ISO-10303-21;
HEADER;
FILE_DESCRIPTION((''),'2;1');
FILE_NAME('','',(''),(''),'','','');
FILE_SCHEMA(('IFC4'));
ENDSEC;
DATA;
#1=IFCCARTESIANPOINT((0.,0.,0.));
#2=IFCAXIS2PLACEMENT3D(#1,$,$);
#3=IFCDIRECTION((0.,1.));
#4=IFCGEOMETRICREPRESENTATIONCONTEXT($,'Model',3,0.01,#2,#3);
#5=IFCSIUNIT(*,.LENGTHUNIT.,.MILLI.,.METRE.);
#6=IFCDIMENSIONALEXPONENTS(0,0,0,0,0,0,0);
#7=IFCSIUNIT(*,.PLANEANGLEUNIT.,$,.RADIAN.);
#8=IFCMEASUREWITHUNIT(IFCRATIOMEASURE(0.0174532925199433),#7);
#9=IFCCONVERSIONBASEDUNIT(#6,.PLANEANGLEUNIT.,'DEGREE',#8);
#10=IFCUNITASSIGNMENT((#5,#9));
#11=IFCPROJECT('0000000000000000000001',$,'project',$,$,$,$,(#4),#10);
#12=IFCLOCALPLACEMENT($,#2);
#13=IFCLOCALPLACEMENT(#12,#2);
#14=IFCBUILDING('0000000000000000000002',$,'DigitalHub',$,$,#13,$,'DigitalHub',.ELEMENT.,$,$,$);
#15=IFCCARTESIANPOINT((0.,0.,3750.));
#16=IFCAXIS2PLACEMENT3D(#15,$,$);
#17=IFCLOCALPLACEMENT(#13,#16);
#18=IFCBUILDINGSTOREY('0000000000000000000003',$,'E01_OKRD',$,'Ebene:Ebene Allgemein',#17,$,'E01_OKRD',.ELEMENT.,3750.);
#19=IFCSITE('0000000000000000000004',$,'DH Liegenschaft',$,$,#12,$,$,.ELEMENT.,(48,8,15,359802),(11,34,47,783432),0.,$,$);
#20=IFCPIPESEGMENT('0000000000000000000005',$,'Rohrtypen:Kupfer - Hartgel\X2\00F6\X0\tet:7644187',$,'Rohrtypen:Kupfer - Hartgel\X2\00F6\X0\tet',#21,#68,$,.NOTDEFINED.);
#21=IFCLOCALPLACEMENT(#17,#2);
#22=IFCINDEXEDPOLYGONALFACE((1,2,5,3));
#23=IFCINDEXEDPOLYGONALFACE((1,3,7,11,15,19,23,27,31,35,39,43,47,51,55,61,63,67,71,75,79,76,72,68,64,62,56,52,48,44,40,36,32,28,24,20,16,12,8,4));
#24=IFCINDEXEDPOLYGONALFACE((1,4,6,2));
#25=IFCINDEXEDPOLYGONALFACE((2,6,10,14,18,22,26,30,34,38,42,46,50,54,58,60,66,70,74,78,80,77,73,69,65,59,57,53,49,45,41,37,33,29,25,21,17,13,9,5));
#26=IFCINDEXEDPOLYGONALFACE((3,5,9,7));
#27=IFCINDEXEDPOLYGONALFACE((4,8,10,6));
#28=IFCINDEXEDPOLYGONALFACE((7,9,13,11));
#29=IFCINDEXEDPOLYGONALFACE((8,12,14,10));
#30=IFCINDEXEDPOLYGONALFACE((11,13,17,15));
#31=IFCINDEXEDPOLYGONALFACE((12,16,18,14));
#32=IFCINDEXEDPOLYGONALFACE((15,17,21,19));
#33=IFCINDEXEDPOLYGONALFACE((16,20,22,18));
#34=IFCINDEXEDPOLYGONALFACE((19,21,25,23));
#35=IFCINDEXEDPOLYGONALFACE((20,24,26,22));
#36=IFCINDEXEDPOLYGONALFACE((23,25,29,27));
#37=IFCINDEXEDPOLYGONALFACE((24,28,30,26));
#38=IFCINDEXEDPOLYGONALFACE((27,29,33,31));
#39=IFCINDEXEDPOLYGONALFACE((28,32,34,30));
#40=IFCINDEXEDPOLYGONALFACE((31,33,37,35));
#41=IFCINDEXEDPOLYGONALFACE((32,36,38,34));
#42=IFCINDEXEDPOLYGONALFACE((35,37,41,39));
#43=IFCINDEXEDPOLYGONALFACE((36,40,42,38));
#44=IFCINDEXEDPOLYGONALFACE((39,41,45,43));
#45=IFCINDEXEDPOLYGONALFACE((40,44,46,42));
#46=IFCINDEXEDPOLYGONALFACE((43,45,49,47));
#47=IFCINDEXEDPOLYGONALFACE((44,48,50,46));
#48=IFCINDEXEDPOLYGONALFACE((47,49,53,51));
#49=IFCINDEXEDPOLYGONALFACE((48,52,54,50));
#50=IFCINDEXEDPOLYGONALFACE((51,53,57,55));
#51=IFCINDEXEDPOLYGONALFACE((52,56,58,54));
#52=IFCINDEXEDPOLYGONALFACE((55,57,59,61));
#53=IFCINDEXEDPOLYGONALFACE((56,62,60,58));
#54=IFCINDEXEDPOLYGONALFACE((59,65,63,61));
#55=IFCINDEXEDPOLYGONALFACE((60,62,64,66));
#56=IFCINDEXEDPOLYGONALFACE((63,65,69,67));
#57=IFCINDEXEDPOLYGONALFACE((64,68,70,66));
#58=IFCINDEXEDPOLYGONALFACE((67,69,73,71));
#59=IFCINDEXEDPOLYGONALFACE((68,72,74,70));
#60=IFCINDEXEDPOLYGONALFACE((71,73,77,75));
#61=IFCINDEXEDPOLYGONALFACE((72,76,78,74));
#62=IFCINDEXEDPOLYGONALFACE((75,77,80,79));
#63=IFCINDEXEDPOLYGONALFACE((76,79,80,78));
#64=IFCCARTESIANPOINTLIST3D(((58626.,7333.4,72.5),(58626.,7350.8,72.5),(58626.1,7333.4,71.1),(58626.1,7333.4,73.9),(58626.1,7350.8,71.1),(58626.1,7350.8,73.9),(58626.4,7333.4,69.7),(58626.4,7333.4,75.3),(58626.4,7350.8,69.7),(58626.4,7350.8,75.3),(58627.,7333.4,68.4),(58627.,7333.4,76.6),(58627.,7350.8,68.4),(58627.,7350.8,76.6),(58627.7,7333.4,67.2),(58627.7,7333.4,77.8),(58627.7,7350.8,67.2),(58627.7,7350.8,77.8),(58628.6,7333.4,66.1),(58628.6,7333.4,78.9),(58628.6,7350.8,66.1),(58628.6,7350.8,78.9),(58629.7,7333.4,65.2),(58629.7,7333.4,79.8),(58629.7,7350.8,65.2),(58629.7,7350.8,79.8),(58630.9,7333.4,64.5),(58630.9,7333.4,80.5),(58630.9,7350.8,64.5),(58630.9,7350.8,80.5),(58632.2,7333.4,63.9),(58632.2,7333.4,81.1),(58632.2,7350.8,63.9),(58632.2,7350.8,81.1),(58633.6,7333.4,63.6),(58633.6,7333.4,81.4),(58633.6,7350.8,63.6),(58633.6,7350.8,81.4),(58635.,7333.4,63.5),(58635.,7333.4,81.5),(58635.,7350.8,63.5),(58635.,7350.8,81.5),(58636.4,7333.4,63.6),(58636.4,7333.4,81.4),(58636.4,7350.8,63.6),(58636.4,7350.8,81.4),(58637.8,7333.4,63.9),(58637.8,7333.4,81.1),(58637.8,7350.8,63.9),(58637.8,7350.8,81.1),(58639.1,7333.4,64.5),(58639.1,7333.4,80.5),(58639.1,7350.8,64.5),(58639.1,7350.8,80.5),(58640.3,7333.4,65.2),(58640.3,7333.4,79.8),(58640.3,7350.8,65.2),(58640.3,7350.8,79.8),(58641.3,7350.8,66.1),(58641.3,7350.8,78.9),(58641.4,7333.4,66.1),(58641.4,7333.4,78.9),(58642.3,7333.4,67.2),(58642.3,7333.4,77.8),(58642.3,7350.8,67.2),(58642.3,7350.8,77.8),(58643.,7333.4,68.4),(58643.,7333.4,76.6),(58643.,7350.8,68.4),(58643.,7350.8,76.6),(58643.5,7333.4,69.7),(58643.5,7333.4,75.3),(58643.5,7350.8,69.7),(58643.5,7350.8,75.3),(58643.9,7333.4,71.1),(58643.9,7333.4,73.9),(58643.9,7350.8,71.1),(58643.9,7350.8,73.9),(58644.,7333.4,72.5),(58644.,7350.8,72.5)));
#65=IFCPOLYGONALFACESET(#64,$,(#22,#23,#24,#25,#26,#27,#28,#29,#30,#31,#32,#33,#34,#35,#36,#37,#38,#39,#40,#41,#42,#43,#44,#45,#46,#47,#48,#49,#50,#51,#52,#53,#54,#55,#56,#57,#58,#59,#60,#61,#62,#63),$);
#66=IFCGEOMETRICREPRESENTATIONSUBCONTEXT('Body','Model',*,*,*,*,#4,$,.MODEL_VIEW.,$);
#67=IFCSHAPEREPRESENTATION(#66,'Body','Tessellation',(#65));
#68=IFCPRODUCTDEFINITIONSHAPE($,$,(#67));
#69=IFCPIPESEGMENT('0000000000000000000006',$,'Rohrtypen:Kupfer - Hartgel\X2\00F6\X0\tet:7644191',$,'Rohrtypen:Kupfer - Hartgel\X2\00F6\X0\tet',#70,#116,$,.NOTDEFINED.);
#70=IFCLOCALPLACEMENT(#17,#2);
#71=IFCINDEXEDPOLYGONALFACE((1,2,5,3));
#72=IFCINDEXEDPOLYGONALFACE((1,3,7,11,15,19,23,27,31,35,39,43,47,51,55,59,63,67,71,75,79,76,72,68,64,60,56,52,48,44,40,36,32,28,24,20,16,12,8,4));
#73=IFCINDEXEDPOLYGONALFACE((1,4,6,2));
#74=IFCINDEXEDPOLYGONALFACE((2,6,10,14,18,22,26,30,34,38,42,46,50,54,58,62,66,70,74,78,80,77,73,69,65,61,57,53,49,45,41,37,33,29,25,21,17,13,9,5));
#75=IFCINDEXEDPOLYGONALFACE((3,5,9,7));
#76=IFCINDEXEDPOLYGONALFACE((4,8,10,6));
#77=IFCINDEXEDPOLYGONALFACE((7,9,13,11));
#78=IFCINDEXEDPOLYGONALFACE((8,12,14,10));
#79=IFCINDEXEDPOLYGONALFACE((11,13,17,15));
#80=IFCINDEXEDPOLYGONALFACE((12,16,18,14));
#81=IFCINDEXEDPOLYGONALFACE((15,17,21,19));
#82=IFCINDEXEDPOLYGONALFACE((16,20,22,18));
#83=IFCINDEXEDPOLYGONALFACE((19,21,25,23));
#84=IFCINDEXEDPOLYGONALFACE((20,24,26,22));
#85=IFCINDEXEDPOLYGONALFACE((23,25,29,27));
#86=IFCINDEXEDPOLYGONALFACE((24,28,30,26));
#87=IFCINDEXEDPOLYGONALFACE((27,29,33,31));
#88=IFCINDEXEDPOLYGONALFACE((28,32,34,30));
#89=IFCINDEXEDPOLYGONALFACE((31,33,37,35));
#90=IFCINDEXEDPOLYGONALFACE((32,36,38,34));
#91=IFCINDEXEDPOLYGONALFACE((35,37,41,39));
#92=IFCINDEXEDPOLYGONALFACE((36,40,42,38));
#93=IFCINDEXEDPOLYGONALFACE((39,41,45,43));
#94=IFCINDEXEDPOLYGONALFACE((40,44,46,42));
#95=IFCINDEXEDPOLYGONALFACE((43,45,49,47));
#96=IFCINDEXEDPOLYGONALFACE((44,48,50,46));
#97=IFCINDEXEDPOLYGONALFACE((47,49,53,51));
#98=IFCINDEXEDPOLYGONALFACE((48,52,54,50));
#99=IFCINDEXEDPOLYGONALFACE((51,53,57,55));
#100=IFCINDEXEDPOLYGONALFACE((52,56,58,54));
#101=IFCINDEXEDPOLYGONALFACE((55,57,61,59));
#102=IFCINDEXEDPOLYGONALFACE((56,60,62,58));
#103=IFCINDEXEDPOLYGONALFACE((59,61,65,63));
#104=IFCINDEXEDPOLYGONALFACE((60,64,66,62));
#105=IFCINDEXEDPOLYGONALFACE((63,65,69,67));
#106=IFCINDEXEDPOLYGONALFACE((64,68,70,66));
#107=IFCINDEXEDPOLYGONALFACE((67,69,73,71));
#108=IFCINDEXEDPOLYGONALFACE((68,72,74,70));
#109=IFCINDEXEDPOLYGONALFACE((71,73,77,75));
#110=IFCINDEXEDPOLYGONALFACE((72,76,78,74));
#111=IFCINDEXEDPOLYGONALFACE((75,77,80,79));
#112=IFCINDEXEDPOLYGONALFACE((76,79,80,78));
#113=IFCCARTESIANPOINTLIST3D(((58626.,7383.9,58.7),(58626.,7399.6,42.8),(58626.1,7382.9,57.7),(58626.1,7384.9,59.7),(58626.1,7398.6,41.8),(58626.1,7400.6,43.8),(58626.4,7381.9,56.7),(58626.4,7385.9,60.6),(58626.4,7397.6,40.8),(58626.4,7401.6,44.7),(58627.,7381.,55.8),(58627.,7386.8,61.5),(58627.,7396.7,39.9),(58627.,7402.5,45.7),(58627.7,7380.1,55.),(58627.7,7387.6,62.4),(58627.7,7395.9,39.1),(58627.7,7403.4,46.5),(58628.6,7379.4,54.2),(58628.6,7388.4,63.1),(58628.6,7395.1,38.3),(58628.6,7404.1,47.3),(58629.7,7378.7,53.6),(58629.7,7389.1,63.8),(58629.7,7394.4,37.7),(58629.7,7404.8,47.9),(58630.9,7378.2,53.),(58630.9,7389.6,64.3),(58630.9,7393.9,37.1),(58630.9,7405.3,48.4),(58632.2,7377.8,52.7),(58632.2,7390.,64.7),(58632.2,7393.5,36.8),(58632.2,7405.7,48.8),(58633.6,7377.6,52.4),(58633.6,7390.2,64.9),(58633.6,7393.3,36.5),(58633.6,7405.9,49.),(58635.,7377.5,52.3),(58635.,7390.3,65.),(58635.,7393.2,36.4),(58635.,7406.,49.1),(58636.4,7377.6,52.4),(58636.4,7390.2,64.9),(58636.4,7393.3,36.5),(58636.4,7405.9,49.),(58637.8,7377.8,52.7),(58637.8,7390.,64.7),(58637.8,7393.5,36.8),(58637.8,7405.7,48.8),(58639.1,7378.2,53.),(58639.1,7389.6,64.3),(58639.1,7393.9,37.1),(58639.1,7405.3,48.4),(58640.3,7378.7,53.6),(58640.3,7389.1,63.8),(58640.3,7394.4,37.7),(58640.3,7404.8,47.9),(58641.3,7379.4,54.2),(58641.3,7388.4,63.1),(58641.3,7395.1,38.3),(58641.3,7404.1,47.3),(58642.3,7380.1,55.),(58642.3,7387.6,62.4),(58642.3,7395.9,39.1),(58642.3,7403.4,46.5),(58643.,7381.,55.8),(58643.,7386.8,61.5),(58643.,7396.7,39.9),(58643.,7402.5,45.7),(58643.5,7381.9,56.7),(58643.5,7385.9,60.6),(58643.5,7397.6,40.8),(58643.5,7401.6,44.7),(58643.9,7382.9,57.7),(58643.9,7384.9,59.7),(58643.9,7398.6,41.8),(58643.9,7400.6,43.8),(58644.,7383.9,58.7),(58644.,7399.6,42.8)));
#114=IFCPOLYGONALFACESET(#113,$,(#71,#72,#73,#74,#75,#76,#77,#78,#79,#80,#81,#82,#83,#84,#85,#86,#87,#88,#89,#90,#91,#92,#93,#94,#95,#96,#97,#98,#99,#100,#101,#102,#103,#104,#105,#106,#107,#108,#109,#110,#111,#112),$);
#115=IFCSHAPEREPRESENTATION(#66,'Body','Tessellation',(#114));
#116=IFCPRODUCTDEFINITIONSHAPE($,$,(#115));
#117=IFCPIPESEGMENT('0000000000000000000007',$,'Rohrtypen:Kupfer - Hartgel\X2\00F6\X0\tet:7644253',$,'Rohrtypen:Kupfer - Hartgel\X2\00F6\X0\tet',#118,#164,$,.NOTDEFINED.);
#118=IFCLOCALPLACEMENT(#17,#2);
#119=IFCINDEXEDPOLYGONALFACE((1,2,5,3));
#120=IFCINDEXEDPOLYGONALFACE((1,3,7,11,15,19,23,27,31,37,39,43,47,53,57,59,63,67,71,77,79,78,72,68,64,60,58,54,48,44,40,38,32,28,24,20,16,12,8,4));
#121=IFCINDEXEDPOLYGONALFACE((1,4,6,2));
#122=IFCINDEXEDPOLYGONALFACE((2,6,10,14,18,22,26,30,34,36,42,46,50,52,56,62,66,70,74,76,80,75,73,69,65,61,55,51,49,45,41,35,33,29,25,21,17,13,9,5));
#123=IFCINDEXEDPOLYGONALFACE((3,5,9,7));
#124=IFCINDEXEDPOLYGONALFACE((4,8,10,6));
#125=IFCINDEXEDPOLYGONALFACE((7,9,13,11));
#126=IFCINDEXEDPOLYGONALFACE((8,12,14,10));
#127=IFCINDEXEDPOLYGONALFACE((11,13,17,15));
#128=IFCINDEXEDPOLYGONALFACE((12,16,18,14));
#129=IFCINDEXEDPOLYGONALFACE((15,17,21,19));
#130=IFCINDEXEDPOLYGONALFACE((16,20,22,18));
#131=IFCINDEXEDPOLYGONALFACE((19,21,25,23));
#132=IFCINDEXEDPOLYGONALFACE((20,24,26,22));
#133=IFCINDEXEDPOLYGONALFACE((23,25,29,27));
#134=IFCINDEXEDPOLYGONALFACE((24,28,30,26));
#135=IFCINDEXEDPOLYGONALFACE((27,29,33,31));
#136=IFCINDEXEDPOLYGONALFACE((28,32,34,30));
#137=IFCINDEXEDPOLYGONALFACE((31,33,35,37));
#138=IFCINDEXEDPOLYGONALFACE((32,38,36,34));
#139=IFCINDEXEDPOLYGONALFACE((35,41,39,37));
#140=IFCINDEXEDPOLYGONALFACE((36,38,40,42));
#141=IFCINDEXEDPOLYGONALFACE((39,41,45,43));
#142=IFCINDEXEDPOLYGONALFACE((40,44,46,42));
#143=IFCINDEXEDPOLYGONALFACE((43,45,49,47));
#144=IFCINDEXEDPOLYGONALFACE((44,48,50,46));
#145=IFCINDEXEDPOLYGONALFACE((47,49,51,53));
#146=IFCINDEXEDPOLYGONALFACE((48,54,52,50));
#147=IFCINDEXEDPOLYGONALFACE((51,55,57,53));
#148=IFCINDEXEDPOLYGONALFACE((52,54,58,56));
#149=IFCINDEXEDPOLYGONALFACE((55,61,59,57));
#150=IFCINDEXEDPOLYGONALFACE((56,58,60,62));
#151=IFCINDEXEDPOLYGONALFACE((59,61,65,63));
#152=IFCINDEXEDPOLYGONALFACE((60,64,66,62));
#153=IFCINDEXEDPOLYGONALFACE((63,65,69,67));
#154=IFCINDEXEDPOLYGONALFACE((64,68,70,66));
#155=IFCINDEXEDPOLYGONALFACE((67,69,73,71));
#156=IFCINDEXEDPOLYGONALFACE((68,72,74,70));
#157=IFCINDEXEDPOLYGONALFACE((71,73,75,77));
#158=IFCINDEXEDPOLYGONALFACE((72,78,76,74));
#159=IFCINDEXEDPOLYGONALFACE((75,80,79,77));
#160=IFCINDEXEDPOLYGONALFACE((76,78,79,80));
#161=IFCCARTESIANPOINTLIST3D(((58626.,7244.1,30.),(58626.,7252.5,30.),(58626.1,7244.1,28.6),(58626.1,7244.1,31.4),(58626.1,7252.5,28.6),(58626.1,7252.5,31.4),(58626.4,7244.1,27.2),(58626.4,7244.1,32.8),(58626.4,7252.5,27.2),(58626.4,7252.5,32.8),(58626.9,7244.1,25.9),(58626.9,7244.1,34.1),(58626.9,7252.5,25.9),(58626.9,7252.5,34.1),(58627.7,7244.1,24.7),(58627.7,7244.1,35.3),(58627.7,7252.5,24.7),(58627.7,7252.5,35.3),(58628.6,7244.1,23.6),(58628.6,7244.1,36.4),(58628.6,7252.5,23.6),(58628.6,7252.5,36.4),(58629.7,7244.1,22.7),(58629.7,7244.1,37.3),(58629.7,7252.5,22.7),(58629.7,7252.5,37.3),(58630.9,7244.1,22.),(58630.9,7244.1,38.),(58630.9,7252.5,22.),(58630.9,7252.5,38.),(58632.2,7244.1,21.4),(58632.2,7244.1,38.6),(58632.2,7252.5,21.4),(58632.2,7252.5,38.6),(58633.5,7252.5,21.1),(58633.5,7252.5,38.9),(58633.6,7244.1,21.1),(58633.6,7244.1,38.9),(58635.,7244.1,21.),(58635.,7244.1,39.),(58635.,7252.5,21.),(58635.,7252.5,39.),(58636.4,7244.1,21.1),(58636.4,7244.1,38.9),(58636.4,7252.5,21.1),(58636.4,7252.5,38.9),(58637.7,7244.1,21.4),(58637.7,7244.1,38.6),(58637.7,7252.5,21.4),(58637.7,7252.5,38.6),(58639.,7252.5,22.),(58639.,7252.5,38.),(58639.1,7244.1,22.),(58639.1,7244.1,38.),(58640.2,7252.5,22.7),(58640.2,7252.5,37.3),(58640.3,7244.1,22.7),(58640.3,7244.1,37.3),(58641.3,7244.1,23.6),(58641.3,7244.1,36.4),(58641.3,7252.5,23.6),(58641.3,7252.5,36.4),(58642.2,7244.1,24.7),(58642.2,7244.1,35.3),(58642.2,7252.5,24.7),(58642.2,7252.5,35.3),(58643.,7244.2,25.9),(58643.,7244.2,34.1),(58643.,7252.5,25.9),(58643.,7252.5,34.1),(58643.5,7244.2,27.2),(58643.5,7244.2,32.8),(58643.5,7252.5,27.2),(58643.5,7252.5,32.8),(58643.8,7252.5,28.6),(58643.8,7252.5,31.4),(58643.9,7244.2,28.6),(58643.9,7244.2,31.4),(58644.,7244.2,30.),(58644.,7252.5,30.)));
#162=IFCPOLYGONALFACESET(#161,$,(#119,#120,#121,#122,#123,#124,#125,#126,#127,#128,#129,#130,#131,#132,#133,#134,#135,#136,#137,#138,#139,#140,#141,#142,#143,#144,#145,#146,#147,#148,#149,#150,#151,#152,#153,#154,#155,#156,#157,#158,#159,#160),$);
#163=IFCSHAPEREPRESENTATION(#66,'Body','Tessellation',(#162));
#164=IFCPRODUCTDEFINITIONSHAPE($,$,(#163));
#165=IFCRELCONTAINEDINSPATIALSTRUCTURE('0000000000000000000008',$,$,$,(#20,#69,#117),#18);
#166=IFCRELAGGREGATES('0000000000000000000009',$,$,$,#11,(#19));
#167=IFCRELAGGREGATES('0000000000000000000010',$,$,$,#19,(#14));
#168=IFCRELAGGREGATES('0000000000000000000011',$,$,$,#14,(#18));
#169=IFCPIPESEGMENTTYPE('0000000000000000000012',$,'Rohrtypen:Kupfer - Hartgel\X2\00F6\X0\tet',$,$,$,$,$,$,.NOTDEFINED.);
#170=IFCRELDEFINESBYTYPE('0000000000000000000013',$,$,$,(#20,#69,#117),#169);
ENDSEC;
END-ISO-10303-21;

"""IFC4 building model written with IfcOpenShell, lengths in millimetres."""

from ifc_helpers import new_model, entity, si_unit, converted_unit, direction, frame, origin, place, context, subcontext, project, spatial, indexed_curve, outline, extrude, type_object, element, save


model = new_model("IFC4")

# Units and contexts
model_context = context("Model", 3, precision=0.01, world=origin(), true_north=direction((0.0, 1.0)))
body_context = subcontext(model_context, "Body", "Model", "MODEL_VIEW")
ifc_project = project(units=[si_unit("LENGTHUNIT", "METRE", prefix="MILLI"), converted_unit("PLANEANGLEUNIT", "DEGREE", entity("IfcRatioMeasure", 0.0174532925199433), si_unit("PLANEANGLEUNIT", "RADIAN"), dimensions=[0, 0, 0, 0, 0, 0, 0])], contexts=[model_context])

# Site, building, storey
site_placement = place(None, origin())
site = spatial("IfcSite", under=ifc_project, at=site_placement, Name="DH Liegenschaft", CompositionType="ELEMENT", RefLatitude=(48, 8, 15, 359802), RefLongitude=(11, 34, 47, 783432), RefElevation=0.0)
building_placement = place(site_placement, origin())
building = spatial("IfcBuilding", under=site, at=building_placement, Name="DigitalHub", LongName="DigitalHub", CompositionType="ELEMENT")
storey_placement = place(building_placement, frame((0.0, 0.0, 3750.0)))
storey = spatial("IfcBuildingStorey", under=building, at=storey_placement, Name="E01_OKRD", ObjectType="Ebene:Ebene Allgemein", LongName="E01_OKRD", CompositionType="ELEMENT", Elevation=3750.0)

# Pipe segments
pipe_segment_type = type_object("IfcPipeSegmentType", Name="Rohrtypen:Kupfer - Hartgelötet", PredefinedType="NOTDEFINED")
pipe_segment_1_placement = place(storey_placement, frame((58624.4, 7333.4, 61.9)))
element("IfcPipeSegment", 1, at=pipe_segment_1_placement, inside=storey, type_object=pipe_segment_type, Name="Rohrtypen:Kupfer - Hartgelötet:7644187", ObjectType="Rohrtypen:Kupfer - Hartgelötet", PredefinedType="NOTDEFINED", context=body_context, shape_type="SweptSolid", body=[
    extrude(outline(indexed_curve([(9.0, 0.0), (8.9, 1.4), (8.6, 2.8), (8.0, 4.1), (7.3, 5.3), (6.4, 6.4), (5.3, 7.3), (4.1, 8.0), (2.8, 8.6), (1.4, 8.9), (0.0, 9.0), (-1.4, 8.9), (-2.8, 8.6), (-4.1, 8.0), (-5.3, 7.3), (-6.4, 6.4), (-7.3, 5.3), (-8.0, 4.1), (-8.6, 2.8), (-8.9, 1.4), (-9.0, 0.0), (-8.9, -1.4), (-8.6, -2.8), (-8.0, -4.1), (-7.3, -5.3), (-6.4, -6.4), (-5.3, -7.3), (-4.1, -8.0), (-2.8, -8.6), (-1.4, -8.9), (0.0, -9.0), (1.4, -8.9), (2.8, -8.6), (4.1, -8.0), (5.3, -7.3), (6.4, -6.4), (7.3, -5.3), (8.0, -4.1), (8.6, -2.8), (8.9, -1.4), (9.0, 0.0)], self_intersect=False)), frame((10.6, 17.5, 10.6), z_axis=(0.00028, -1.0, 0.000282), x_axis=(-1.0, -0.00028, 0.0)), (0.0, 0.0, 1.0), 17.5),
])
pipe_segment_2_placement = place(storey_placement, frame((58624.4, 7375.9, 34.9)))
element("IfcPipeSegment", 2, at=pipe_segment_2_placement, inside=storey, type_object=pipe_segment_type, Name="Rohrtypen:Kupfer - Hartgelötet:7644191", ObjectType="Rohrtypen:Kupfer - Hartgelötet", PredefinedType="NOTDEFINED", context=body_context, shape_type="SweptSolid", body=[
    extrude(outline(indexed_curve([(9.0, 0.0), (8.9, 1.4), (8.6, 2.8), (8.0, 4.1), (7.3, 5.3), (6.4, 6.4), (5.3, 7.3), (4.1, 8.0), (2.8, 8.6), (1.4, 8.9), (0.0, 9.0), (-1.4, 8.9), (-2.8, 8.6), (-4.1, 8.0), (-5.3, 7.3), (-6.4, 6.4), (-7.3, 5.3), (-8.0, 4.1), (-8.6, 2.8), (-8.9, 1.4), (-9.0, 0.0), (-8.9, -1.4), (-8.6, -2.8), (-8.0, -4.1), (-7.3, -5.3), (-6.4, -6.4), (-5.3, -7.3), (-4.1, -8.0), (-2.8, -8.6), (-1.4, -8.9), (0.0, -9.0), (1.4, -8.9), (2.8, -8.6), (4.1, -8.0), (5.3, -7.3), (6.4, -6.4), (7.3, -5.3), (8.0, -4.1), (8.6, -2.8), (8.9, -1.4), (9.0, 0.0)], self_intersect=False)), frame((10.6, 8.0, 23.8), z_axis=(0.000002, 0.703257, -0.710936), x_axis=(-1.0, 0.000003, 0.0)), (0.0, 0.0, 1.0), 22.4),
])
pipe_segment_3_placement = place(storey_placement, frame((58624.4, 7244.1, 19.4)))
element("IfcPipeSegment", 3, at=pipe_segment_3_placement, inside=storey, type_object=pipe_segment_type, Name="Rohrtypen:Kupfer - Hartgelötet:7644253", ObjectType="Rohrtypen:Kupfer - Hartgelötet", PredefinedType="NOTDEFINED", context=body_context, shape_type="SweptSolid", body=[
    extrude(outline(indexed_curve([(9.0, 0.0), (8.9, 1.4), (8.6, 2.8), (8.0, 4.1), (7.3, 5.3), (6.4, 6.4), (5.3, 7.3), (4.1, 8.0), (2.8, 8.6), (1.4, 8.9), (0.0, 9.0), (-1.4, 8.9), (-2.8, 8.6), (-4.1, 8.0), (-5.3, 7.3), (-6.4, 6.4), (-7.3, 5.3), (-8.0, 4.1), (-8.6, 2.8), (-8.9, 1.4), (-9.0, 0.0), (-8.9, -1.4), (-8.6, -2.8), (-8.0, -4.1), (-7.3, -5.3), (-6.4, -6.4), (-5.3, -7.3), (-4.1, -8.0), (-2.8, -8.6), (-1.4, -8.9), (0.0, -9.0), (1.4, -8.9), (2.8, -8.6), (4.1, -8.0), (5.3, -7.3), (6.4, -6.4), (7.3, -5.3), (8.0, -4.1), (8.6, -2.8), (8.9, -1.4), (9.0, 0.0)], self_intersect=False)), frame((10.6, 0.0, 10.6), z_axis=(-0.00127, 0.999999, 0.0), x_axis=(-0.999999, -0.00127, 0.0)), (0.0, 0.0, 1.0), 8.3),
])

save(model, "model.ifc")
